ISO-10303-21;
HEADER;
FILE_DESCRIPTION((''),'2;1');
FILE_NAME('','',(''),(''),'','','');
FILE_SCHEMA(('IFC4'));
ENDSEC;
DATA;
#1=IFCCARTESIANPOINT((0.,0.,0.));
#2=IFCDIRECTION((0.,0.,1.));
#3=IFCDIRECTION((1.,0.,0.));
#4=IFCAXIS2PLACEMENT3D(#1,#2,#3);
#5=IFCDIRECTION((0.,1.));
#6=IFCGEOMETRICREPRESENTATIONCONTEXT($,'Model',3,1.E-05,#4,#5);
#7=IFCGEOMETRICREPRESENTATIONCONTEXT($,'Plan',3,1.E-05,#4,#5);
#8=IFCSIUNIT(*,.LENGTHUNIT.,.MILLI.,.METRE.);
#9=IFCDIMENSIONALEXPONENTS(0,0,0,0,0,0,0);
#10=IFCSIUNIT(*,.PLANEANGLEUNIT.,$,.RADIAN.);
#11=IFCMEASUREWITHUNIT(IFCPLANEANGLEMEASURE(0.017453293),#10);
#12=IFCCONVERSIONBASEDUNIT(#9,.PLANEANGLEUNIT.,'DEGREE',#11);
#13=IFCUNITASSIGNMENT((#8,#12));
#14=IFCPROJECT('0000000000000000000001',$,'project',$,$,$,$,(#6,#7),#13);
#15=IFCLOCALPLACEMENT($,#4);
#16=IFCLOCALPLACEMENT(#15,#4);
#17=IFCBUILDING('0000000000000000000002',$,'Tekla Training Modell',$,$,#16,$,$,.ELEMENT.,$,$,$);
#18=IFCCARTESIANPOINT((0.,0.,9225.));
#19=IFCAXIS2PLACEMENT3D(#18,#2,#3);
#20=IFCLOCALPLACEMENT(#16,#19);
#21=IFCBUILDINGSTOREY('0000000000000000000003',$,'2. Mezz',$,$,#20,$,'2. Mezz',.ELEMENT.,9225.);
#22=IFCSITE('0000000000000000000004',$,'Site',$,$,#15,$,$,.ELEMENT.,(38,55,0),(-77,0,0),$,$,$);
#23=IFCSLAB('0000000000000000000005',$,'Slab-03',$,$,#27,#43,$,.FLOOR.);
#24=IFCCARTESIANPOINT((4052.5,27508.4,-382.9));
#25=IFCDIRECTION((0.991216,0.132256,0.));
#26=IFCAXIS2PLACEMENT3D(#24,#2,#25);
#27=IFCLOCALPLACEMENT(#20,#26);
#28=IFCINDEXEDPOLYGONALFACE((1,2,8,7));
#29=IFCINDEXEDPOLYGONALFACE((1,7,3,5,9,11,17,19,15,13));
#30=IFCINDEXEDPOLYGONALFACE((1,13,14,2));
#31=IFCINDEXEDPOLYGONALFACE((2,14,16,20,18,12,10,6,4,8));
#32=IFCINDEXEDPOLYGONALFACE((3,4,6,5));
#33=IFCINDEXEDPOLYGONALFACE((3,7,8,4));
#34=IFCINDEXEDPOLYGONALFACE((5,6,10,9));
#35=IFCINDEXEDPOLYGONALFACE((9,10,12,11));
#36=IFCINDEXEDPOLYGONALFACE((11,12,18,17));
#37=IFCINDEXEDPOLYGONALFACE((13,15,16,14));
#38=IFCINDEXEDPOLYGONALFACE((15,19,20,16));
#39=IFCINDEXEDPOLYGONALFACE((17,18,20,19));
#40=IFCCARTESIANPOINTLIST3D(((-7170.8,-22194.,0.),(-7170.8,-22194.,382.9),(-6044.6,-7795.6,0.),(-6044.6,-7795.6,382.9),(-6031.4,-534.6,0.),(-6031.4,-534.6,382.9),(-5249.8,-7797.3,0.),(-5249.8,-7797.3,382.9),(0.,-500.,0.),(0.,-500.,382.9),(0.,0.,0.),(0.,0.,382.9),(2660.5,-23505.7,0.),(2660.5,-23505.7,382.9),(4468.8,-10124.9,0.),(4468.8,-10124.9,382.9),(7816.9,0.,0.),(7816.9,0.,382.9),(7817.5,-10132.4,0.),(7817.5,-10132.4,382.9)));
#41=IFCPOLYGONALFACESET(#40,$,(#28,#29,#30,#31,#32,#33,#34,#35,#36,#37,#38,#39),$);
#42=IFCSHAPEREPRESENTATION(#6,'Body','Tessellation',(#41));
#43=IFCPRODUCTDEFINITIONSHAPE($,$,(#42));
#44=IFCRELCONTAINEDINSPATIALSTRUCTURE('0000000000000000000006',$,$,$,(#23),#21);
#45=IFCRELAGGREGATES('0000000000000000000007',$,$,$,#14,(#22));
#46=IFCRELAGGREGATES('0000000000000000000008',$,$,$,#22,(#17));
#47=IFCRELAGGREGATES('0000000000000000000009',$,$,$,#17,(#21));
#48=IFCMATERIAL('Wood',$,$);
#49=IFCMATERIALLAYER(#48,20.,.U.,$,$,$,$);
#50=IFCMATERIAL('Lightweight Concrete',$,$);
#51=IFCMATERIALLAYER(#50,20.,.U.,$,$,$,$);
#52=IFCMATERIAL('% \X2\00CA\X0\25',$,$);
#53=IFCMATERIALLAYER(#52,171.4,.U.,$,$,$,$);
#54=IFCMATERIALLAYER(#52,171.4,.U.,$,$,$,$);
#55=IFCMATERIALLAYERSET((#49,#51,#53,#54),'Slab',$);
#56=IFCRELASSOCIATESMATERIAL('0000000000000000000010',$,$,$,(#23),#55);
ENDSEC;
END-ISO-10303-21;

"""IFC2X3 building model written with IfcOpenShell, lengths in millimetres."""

from ifc_helpers import new_model, entity, si_unit, converted_unit, direction, frame, origin_with_axes, place, context, project, spatial, polyline, outline, extrude, material, layer, layer_set, layer_usage, element, save


model = new_model("IFC2X3")

# Units and contexts
model_context = context("Model", 3, precision=1e-05, world=origin_with_axes(), true_north=direction((0.0, 1.0)))
plan_context = context("Plan", 3, precision=1e-05, world=origin_with_axes(), true_north=direction((0.0, 1.0)))
ifc_project = project(units=[si_unit("LENGTHUNIT", "METRE", prefix="MILLI"), converted_unit("PLANEANGLEUNIT", "DEGREE", entity("IfcPlaneAngleMeasure", 0.017453293), si_unit("PLANEANGLEUNIT", "RADIAN"), dimensions=[0, 0, 0, 0, 0, 0, 0])], contexts=[model_context, plan_context])

# Site, building, storey
site_placement = place(None, origin_with_axes())
site = spatial("IfcSite", under=ifc_project, at=site_placement, Name="Site", CompositionType="ELEMENT", RefLatitude=(38, 55, 0), RefLongitude=(-77, 0, 0))
building_placement = place(site_placement, origin_with_axes())
building = spatial("IfcBuilding", under=site, at=building_placement, Name="Tekla Training Modell", CompositionType="ELEMENT")
storey_placement = place(building_placement, frame((0.0, 0.0, 9225.0), z_axis=(0.0, 0.0, 1.0), x_axis=(1.0, 0.0, 0.0)))
storey = spatial("IfcBuildingStorey", under=building, at=storey_placement, Name="2. Mezz", LongName="2. Mezz", CompositionType="ELEMENT", Elevation=9225.0)

# Slab
ifc_material_1 = material(Name="Wood")
ifc_layer_1 = layer(ifc_material_1, 20.0, ventilated="UNKNOWN")
ifc_material_2 = material(Name="Lightweight Concrete")
ifc_layer_2 = layer(ifc_material_2, 20.0, ventilated="UNKNOWN")
ifc_material_3 = material(Name="% Ê25")
ifc_layer_3 = layer(ifc_material_3, 171.4, ventilated="UNKNOWN")
ifc_layer_4 = layer(ifc_material_3, 171.4, ventilated="UNKNOWN")
ifc_layer_set_1 = layer_set([ifc_layer_1, ifc_layer_2, ifc_layer_3, ifc_layer_4], Name="Slab")
ifc_layer_usage_1 = layer_usage(ifc_layer_set_1, "AXIS3", "NEGATIVE", 382.9)
slab_placement = place(storey_placement, frame((4052.5, 27508.4, -382.9), z_axis=(0.0, 0.0, 1.0), x_axis=(0.991216, 0.132256, 0.0)))
element("IfcSlab", 1, at=slab_placement, inside=storey, material=ifc_layer_usage_1, Name="Slab-03", PredefinedType="FLOOR", context=model_context, shape_type="SweptSolid", body=[
    extrude(outline(polyline([(0.0, 0.0), (7816.9, 0.0), (7817.5, -10132.4), (4468.8, -10124.9), (2660.5, -23505.7), (-7170.8, -22194.0), (-5249.8, -7797.3), (-6044.6, -7795.6), (-6031.4, -534.6), (0.0, -500.0), (0.0, 0.0)])), origin_with_axes(), (0.0, 0.0, 1.0), 382.9),
])

save(model, "model.ifc")
